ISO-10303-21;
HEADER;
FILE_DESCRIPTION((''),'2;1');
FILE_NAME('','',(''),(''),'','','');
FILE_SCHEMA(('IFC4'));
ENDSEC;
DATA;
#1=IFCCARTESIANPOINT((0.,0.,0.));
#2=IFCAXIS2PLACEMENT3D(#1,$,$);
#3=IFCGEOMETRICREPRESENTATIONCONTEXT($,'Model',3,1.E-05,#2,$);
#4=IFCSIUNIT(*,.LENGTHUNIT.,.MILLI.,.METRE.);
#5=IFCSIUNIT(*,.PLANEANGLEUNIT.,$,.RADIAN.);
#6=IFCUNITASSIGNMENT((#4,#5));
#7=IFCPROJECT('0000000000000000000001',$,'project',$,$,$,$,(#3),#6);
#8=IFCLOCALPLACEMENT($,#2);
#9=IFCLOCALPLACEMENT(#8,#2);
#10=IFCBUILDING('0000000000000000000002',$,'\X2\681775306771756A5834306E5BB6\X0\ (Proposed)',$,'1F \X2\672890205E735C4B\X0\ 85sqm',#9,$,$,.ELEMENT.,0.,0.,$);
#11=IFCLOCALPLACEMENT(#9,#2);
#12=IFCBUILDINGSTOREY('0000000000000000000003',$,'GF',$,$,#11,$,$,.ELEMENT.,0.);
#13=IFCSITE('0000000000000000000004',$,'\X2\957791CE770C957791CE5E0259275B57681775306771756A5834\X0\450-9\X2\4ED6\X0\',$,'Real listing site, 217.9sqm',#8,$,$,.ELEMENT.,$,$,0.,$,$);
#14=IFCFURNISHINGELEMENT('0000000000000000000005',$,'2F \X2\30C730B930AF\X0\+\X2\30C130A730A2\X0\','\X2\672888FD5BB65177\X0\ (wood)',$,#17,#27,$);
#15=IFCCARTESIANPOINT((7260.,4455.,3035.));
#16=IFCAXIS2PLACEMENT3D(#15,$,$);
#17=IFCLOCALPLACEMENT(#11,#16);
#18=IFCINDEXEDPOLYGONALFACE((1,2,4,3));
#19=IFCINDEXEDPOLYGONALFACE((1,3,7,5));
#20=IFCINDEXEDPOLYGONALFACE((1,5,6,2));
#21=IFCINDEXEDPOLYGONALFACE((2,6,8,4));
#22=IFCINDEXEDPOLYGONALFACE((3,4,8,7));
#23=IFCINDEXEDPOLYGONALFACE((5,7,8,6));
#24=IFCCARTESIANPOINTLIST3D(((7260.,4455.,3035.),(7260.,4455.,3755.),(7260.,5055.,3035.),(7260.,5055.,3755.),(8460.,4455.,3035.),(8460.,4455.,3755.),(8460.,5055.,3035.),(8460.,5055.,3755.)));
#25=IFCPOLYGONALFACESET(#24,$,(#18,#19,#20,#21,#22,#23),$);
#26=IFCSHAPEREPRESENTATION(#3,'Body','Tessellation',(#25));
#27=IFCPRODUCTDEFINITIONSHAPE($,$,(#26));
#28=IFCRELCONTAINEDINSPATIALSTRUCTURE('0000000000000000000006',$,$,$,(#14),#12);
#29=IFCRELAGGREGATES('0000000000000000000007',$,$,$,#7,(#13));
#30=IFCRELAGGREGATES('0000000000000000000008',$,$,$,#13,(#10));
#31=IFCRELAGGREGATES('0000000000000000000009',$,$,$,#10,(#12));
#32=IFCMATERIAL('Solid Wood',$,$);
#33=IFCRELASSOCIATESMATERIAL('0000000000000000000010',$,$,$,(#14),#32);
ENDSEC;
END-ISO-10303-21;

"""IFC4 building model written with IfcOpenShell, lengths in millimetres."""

from ifc_helpers import new_model, si_unit, frame, frame_2d, origin, place, context, project, spatial, rectangle, extrude, material, element, save


model = new_model("IFC4")

# Units and contexts
model_context = context("Model", 3, precision=1e-05, world=origin())
ifc_project = project(units=[si_unit("LENGTHUNIT", "METRE", prefix="MILLI"), si_unit("PLANEANGLEUNIT", "RADIAN")], contexts=[model_context])

# Site, building, storey
site_placement = place(None, origin())
site = spatial("IfcSite", under=ifc_project, at=site_placement, Name="長野県長野市大字栗田東番場450-9他", ObjectType="Real listing site, 217.9sqm", CompositionType="ELEMENT", RefElevation=0.0)
building_placement = place(site_placement, origin())
building = spatial("IfcBuilding", under=site, at=building_placement, Name="栗田東番場の家 (Proposed)", ObjectType="1F 木造平屋 85sqm", CompositionType="ELEMENT", ElevationOfRefHeight=0.0, ElevationOfTerrain=0.0)
storey_placement = place(building_placement, origin())
storey = spatial("IfcBuildingStorey", under=building, at=storey_placement, Name="GF", CompositionType="ELEMENT", Elevation=0.0)

# Shared definitions
ifc_material_1 = material(Name="Solid Wood")

# Furnishing element
furnishing_1_placement = place(storey_placement, frame((7260.0, 4455.0, 3035.0)))
element("IfcFurnishingElement", 1, at=furnishing_1_placement, inside=storey, material=ifc_material_1, Name="2F デスク+チェア", Description="木製家具 (wood)", context=model_context, shape_type="SweptSolid", body=[
    extrude(rectangle(XDim=1200.0, YDim=600.0, at=frame_2d((600.0, 300.0))), frame((7260.0, 4455.0, 3035.0)), (0.0, 0.0, 1.0), 720.0),
])

save(model, "model.ifc")
